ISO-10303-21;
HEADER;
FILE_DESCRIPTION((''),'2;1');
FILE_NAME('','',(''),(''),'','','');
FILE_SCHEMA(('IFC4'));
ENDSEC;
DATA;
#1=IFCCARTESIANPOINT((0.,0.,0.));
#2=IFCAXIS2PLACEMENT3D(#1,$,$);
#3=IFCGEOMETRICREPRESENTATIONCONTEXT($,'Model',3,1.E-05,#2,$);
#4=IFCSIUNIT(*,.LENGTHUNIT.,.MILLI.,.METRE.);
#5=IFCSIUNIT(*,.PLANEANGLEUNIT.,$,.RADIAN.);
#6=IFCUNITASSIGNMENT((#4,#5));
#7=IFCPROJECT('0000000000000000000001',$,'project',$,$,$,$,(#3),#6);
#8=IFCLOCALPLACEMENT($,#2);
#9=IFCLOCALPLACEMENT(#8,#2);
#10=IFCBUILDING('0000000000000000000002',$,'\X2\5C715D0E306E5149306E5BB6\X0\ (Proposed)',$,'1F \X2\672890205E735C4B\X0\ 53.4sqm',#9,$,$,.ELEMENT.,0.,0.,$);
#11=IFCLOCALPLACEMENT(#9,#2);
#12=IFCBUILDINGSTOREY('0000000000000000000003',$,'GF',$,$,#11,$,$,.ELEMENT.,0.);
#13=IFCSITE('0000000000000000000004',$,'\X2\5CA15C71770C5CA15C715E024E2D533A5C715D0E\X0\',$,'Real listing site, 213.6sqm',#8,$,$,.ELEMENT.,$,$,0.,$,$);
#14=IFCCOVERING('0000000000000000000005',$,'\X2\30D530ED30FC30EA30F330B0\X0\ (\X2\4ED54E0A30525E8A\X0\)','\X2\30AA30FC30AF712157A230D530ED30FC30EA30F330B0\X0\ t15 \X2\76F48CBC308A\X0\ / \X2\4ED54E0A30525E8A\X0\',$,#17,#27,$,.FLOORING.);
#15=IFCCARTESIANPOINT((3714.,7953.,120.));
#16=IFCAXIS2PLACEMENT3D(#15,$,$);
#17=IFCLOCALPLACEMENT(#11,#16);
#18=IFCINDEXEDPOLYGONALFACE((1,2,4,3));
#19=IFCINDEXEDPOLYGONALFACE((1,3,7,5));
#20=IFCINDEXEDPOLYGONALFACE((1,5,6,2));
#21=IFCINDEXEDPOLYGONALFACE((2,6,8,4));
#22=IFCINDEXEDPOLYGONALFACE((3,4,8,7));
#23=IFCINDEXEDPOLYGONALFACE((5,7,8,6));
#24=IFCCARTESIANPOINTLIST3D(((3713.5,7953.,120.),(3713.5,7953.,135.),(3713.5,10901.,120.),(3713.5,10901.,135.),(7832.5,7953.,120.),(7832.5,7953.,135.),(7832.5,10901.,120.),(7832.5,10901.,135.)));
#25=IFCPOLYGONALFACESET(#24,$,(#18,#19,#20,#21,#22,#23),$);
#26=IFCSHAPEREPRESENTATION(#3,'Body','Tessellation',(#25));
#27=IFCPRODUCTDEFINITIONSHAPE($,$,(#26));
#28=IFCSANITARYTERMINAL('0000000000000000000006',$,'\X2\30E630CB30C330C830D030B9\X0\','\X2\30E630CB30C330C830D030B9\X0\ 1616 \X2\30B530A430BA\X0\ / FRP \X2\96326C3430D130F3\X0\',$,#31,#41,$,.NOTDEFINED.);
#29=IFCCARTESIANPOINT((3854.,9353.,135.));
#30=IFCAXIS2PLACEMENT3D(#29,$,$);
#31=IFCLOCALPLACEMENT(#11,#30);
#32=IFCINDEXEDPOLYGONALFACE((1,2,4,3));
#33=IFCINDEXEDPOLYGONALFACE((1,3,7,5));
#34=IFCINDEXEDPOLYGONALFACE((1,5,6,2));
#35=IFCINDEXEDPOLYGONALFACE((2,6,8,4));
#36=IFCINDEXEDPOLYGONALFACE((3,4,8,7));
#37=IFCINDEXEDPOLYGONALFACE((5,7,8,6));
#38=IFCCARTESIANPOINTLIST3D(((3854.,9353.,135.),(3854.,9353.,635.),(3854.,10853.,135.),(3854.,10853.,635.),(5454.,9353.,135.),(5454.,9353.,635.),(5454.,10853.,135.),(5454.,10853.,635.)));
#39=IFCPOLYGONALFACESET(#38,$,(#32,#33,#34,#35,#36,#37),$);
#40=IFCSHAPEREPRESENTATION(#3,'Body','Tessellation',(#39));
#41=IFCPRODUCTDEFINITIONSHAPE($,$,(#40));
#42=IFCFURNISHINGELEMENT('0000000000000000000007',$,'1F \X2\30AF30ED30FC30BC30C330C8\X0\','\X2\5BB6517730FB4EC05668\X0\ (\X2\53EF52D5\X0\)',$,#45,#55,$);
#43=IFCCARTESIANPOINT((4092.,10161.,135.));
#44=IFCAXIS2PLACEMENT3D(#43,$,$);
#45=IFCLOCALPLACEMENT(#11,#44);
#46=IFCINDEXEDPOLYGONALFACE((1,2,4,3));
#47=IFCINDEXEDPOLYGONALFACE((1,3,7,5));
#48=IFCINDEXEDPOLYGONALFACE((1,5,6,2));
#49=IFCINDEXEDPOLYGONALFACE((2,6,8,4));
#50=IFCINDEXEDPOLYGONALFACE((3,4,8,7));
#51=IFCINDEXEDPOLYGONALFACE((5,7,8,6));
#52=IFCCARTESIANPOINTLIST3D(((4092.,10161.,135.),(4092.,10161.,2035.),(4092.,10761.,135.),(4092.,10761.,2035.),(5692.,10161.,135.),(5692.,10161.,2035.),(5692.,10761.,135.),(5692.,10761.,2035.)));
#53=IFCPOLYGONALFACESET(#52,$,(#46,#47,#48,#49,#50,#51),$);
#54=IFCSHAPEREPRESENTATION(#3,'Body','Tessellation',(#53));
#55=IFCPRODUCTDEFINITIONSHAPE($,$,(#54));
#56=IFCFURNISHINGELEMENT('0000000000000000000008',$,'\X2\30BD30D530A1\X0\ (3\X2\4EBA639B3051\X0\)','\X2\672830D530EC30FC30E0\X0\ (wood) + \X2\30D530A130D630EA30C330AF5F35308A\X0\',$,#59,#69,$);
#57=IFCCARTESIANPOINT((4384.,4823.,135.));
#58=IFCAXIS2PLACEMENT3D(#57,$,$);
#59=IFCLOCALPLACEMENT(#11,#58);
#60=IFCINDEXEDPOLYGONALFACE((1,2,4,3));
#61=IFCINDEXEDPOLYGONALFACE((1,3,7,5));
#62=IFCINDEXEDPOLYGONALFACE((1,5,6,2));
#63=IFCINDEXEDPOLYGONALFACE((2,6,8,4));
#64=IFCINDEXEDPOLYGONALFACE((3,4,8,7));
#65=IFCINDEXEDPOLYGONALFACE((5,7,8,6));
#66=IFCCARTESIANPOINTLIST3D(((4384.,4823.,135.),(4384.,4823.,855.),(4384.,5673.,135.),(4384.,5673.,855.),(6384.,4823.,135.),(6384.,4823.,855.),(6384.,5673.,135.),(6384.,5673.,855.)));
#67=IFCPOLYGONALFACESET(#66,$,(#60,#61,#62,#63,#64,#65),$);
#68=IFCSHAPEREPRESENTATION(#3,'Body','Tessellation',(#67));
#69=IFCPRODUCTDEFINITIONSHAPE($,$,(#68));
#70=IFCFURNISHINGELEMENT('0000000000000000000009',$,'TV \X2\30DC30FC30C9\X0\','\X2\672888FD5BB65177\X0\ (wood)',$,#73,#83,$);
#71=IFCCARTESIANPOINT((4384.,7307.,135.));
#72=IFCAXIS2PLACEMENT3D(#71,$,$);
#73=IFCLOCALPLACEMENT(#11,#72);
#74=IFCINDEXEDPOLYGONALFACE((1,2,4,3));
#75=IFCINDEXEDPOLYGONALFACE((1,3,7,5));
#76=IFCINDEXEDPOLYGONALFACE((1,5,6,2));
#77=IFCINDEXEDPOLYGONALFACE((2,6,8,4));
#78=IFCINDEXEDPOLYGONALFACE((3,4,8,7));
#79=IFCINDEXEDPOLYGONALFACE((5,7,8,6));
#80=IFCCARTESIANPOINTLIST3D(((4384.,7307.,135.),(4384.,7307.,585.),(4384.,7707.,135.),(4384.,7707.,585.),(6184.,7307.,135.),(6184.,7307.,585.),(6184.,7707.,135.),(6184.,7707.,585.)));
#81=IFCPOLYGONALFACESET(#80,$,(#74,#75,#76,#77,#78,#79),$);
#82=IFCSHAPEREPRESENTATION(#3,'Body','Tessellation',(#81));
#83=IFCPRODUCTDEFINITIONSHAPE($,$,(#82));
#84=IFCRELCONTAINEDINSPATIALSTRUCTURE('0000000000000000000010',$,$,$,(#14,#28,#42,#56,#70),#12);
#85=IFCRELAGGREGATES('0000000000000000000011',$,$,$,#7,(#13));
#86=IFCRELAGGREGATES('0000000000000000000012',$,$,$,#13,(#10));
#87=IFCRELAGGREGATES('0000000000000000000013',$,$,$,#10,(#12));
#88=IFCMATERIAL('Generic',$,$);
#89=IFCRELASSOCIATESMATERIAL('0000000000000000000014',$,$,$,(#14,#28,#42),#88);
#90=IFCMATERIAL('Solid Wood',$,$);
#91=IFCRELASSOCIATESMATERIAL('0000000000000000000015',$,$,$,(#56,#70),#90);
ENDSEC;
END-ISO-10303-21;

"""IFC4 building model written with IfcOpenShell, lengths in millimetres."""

from ifc_helpers import new_model, si_unit, frame, frame_2d, origin, place, context, project, spatial, rectangle, extrude, material, element, save


model = new_model("IFC4")

# Units and contexts
model_context = context("Model", 3, precision=1e-05, world=origin())
ifc_project = project(units=[si_unit("LENGTHUNIT", "METRE", prefix="MILLI"), si_unit("PLANEANGLEUNIT", "RADIAN")], contexts=[model_context])

# Site, building, storey
site_placement = place(None, origin())
site = spatial("IfcSite", under=ifc_project, at=site_placement, Name="岡山県岡山市中区山崎", ObjectType="Real listing site, 213.6sqm", CompositionType="ELEMENT", RefElevation=0.0)
building_placement = place(site_placement, origin())
building = spatial("IfcBuilding", under=site, at=building_placement, Name="山崎の光の家 (Proposed)", ObjectType="1F 木造平屋 53.4sqm", CompositionType="ELEMENT", ElevationOfRefHeight=0.0, ElevationOfTerrain=0.0)
storey_placement = place(building_placement, origin())
storey = spatial("IfcBuildingStorey", under=building, at=storey_placement, Name="GF", CompositionType="ELEMENT", Elevation=0.0)

# Shared definitions
ifc_material_1 = material(Name="Solid Wood")

# Covering
ifc_material_2 = material(Name="Generic")
covering_1_placement = place(storey_placement, frame((3714.0, 7953.0, 120.0)))
element("IfcCovering", 1, at=covering_1_placement, inside=storey, material=ifc_material_2, Name="フローリング (仕上げ床)", Description="オーク無垢フローリング t15 直貼り / 仕上げ床", PredefinedType="FLOORING", context=model_context, shape_type="SweptSolid", body=[
    extrude(rectangle(XDim=4119.0, YDim=2948.0, at=frame_2d((2059.0, 1474.0))), frame((3714.0, 7953.0, 120.0)), (0.0, 0.0, 1.0), 15.0),
])

# Sanitary terminal
sanitary_terminal_placement = place(storey_placement, frame((3854.0, 9353.0, 135.0)))
element("IfcSanitaryTerminal", 2, at=sanitary_terminal_placement, inside=storey, material=ifc_material_2, Name="ユニットバス", Description="ユニットバス 1616 サイズ / FRP 防水パン", PredefinedType="NOTDEFINED", context=model_context, shape_type="SweptSolid", body=[
    extrude(rectangle(XDim=1600.0, YDim=1500.0, at=frame_2d((800.0, 750.0))), frame((3854.0, 9353.0, 135.0)), (0.0, 0.0, 1.0), 500.0),
])

# Furnishing elements
furnishing_1_placement = place(storey_placement, frame((4092.0, 10161.0, 135.0)))
element("IfcFurnishingElement", 3, at=furnishing_1_placement, inside=storey, material=ifc_material_2, Name="1F クローゼット", Description="家具・什器 (可動)", context=model_context, shape_type="SweptSolid", body=[
    extrude(rectangle(XDim=1600.0, YDim=600.0, at=frame_2d((800.0, 300.0))), frame((4092.0, 10161.0, 135.0)), (0.0, 0.0, 1.0), 1900.0),
])
furnishing_2_placement = place(storey_placement, frame((4384.0, 4823.0, 135.0)))
element("IfcFurnishingElement", 4, at=furnishing_2_placement, inside=storey, material=ifc_material_1, Name="ソファ (3人掛け)", Description="木フレーム (wood) + ファブリック張り", context=model_context, shape_type="SweptSolid", body=[
    extrude(rectangle(XDim=2000.0, YDim=850.0, at=frame_2d((1000.0, 425.0))), frame((4384.0, 4823.0, 135.0)), (0.0, 0.0, 1.0), 720.0),
])
furnishing_3_placement = place(storey_placement, frame((4384.0, 7307.0, 135.0)))
element("IfcFurnishingElement", 5, at=furnishing_3_placement, inside=storey, material=ifc_material_1, Name="TV ボード", Description="木製家具 (wood)", context=model_context, shape_type="SweptSolid", body=[
    extrude(rectangle(XDim=1800.0, YDim=400.0, at=frame_2d((900.0, 200.0))), frame((4384.0, 7307.0, 135.0)), (0.0, 0.0, 1.0), 450.0),
])

save(model, "model.ifc")
